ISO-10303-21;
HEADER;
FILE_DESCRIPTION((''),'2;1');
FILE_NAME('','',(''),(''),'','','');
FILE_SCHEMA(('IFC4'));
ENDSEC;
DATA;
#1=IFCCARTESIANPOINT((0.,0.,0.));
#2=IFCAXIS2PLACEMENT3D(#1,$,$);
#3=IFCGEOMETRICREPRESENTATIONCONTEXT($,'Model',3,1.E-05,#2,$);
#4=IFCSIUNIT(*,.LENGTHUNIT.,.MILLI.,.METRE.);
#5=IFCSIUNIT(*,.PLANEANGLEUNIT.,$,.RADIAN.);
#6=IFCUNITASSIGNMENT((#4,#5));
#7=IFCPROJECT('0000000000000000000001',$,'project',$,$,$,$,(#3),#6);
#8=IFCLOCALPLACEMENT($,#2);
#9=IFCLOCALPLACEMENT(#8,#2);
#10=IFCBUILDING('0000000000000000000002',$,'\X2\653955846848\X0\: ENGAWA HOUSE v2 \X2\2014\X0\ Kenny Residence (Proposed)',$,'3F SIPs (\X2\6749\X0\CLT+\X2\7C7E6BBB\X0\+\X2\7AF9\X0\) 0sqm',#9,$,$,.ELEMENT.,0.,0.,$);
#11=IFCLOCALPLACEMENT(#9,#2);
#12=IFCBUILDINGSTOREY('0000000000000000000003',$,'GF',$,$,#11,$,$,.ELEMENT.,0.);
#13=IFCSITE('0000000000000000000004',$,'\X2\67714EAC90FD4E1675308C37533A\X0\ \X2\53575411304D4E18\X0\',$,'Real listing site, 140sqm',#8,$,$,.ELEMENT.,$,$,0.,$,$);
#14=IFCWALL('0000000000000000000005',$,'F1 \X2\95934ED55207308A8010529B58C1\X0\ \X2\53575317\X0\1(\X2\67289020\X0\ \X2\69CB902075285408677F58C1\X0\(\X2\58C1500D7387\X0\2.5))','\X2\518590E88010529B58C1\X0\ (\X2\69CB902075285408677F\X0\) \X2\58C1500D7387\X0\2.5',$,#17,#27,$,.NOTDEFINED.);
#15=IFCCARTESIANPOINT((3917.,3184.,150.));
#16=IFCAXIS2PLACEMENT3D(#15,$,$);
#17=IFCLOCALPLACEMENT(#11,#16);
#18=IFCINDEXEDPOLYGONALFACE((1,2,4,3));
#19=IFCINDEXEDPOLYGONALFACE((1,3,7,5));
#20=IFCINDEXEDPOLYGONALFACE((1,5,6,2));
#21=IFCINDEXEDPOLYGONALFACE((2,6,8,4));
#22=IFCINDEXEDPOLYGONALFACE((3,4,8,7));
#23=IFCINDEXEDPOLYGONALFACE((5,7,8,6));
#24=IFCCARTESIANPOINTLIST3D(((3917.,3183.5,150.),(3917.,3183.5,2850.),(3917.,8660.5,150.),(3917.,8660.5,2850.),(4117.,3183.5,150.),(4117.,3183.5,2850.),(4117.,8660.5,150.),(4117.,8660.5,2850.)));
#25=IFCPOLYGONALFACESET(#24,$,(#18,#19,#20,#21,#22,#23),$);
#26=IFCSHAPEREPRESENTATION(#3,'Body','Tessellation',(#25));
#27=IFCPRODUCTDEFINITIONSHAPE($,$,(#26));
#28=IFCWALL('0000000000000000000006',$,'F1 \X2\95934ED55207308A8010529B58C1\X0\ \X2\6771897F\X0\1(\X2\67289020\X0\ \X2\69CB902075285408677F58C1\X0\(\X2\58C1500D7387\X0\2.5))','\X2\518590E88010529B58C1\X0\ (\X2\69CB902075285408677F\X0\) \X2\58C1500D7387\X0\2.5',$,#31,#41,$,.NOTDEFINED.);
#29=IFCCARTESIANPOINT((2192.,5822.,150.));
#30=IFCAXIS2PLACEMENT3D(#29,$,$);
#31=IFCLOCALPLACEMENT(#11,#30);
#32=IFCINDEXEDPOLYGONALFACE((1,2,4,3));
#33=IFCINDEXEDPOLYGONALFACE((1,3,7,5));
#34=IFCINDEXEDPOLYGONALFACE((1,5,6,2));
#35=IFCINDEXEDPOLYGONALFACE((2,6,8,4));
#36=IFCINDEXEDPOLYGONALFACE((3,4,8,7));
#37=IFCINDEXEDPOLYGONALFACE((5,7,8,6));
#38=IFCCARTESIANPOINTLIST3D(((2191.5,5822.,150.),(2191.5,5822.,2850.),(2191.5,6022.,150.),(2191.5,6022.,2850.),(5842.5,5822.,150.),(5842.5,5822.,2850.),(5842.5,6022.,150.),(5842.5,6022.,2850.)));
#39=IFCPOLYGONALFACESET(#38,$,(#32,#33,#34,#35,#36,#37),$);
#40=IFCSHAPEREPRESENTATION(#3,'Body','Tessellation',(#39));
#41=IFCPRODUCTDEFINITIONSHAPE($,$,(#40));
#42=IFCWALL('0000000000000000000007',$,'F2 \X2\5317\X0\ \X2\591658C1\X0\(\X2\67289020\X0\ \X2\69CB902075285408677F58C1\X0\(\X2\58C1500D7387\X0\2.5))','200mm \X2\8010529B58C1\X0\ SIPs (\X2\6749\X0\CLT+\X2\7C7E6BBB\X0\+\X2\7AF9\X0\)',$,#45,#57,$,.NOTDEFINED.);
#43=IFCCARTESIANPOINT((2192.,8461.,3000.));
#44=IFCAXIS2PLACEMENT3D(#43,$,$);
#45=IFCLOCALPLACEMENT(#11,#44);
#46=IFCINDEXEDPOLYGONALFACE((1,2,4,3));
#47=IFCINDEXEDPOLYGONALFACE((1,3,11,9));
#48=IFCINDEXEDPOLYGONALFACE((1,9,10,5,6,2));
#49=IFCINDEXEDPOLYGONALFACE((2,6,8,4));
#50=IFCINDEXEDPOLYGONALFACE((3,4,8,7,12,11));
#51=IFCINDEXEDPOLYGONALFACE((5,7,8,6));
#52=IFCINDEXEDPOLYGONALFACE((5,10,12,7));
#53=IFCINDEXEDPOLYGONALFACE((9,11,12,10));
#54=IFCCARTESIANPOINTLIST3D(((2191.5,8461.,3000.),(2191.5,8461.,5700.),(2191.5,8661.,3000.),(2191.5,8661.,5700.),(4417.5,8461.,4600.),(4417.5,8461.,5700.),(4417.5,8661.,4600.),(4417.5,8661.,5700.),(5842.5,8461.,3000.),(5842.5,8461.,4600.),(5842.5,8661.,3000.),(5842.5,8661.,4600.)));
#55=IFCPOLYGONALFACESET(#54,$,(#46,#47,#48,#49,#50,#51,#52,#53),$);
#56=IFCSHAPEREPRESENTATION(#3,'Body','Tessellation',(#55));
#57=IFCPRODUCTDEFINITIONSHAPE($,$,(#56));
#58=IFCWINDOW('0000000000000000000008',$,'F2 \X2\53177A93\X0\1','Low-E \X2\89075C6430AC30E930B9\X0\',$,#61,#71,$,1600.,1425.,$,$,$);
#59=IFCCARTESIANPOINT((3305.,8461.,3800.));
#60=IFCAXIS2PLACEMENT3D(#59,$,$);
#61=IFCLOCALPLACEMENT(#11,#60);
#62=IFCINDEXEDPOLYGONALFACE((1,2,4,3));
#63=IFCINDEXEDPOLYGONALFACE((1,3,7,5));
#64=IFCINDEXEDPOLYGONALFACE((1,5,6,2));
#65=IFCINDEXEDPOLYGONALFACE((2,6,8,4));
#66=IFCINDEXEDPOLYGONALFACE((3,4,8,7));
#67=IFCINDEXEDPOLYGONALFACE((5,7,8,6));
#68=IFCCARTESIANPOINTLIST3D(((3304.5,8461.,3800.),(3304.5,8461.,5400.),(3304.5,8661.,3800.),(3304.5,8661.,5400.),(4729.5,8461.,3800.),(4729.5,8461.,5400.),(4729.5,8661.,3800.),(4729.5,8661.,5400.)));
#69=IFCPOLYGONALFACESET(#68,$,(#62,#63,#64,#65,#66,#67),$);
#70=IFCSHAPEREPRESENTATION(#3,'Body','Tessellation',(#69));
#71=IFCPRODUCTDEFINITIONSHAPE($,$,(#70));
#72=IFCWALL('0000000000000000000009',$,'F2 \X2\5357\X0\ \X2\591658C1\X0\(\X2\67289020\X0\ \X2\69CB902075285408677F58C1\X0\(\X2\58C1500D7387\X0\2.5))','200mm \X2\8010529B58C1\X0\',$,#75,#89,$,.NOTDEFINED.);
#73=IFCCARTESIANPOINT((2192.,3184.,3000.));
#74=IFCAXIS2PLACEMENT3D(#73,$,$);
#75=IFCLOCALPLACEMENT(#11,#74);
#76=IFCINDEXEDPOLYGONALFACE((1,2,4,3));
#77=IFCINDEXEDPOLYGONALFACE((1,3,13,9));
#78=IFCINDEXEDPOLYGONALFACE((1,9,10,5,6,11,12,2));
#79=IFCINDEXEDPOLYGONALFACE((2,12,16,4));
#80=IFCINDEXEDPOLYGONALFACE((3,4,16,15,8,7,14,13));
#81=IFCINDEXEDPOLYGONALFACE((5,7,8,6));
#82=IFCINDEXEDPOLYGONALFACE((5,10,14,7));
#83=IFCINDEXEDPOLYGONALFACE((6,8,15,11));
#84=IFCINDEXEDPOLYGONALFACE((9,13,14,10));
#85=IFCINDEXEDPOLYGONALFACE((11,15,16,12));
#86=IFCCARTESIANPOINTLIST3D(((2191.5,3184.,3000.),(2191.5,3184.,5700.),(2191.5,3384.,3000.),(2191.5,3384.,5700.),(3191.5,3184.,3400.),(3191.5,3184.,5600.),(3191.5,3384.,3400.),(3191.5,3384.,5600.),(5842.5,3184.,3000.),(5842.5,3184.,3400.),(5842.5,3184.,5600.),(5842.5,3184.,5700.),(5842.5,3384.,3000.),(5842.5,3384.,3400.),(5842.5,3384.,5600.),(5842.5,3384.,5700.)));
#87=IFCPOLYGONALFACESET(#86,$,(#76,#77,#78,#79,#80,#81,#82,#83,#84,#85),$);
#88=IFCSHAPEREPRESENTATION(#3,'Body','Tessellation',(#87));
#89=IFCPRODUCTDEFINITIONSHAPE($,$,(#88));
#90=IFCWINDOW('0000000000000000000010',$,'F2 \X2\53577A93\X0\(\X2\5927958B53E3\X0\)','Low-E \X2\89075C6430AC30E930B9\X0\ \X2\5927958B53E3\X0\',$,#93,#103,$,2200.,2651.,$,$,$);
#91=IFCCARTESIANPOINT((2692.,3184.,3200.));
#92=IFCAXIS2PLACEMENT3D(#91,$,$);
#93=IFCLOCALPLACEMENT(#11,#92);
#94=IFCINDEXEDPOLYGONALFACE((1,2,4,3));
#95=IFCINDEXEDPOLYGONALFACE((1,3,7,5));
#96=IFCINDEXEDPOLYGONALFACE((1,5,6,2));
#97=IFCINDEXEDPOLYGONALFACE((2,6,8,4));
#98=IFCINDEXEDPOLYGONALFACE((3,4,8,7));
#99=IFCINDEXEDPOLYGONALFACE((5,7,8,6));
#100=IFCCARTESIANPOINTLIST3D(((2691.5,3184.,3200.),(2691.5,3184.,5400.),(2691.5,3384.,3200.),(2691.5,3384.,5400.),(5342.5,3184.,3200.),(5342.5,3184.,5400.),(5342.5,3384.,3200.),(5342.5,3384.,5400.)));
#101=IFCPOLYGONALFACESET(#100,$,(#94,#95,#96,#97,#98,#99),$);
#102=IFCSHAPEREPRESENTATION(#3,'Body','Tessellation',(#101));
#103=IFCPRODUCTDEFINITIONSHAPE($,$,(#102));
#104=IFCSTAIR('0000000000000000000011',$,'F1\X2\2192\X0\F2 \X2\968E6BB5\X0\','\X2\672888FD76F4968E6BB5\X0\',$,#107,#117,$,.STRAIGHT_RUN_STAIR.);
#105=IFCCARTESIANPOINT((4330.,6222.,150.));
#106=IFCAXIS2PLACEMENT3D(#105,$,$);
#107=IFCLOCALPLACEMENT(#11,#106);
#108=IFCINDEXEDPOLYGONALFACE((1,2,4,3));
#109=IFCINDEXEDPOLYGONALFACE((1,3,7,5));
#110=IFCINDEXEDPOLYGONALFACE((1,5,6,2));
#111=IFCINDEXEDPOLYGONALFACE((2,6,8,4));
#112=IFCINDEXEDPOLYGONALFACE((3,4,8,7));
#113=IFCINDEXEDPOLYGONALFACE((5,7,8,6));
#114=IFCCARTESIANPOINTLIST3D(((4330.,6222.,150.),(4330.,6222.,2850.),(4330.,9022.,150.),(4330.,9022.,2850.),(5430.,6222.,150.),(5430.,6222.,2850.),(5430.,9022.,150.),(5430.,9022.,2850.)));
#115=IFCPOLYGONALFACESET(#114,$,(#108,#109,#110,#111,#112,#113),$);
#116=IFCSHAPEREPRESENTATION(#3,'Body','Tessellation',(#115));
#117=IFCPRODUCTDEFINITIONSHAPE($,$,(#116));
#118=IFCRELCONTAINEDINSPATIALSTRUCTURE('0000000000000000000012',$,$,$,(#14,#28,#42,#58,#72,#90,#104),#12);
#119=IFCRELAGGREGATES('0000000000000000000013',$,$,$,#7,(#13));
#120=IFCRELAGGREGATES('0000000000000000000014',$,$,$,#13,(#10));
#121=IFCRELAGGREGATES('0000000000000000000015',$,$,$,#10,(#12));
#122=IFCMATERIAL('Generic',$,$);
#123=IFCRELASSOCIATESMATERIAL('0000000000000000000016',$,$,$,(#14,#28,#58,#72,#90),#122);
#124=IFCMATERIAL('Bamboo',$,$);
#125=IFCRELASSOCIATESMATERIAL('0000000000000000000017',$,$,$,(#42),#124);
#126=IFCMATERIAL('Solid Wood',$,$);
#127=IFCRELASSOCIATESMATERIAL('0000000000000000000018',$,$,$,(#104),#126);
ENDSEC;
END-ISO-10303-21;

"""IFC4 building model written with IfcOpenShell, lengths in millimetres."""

from ifc_helpers import new_model, si_unit, frame, frame_2d, origin, place, context, project, spatial, rectangle, extrude, material, element, fill, save


model = new_model("IFC4")

# Units and contexts
model_context = context("Model", 3, precision=1e-05, world=origin())
ifc_project = project(units=[si_unit("LENGTHUNIT", "METRE", prefix="MILLI"), si_unit("PLANEANGLEUNIT", "RADIAN")], contexts=[model_context])

# Site, building, storey
site_placement = place(None, origin())
site = spatial("IfcSite", under=ifc_project, at=site_placement, Name="東京都世田谷区 南向き丘", ObjectType="Real listing site, 140sqm", CompositionType="ELEMENT", RefElevation=0.0)
building_placement = place(site_placement, origin())
building = spatial("IfcBuilding", under=site, at=building_placement, Name="改善案: ENGAWA HOUSE v2 — Kenny Residence (Proposed)", ObjectType="3F SIPs (杉CLT+籾殻+竹) 0sqm", CompositionType="ELEMENT", ElevationOfRefHeight=0.0, ElevationOfTerrain=0.0)
storey_placement = place(building_placement, origin())
storey = spatial("IfcBuildingStorey", under=building, at=storey_placement, Name="GF", CompositionType="ELEMENT", Elevation=0.0)

# Shared definitions
ifc_material_1 = material(Name="Generic")

# Shared definitions
ifc_material_2 = material(Name="Bamboo")

# Shared definitions
ifc_material_3 = material(Name="Solid Wood")

# Walls
wall_1_placement = place(storey_placement, frame((3917.0, 3184.0, 150.0)))
element("IfcWall", 1, at=wall_1_placement, inside=storey, material=ifc_material_1, Name="F1 間仕切り耐力壁 南北1(木造 構造用合板壁(壁倍率2.5))", Description="内部耐力壁 (構造用合板) 壁倍率2.5", PredefinedType="NOTDEFINED", context=model_context, shape_type="SweptSolid", body=[
    extrude(rectangle(XDim=200.0, YDim=5477.0, at=frame_2d((100.0, 2738.0))), frame((3917.0, 3184.0, 150.0)), (0.0, 0.0, 1.0), 2700.0),
])
wall_2_placement = place(storey_placement, frame((2192.0, 5822.0, 150.0)))
element("IfcWall", 2, at=wall_2_placement, inside=storey, material=ifc_material_1, Name="F1 間仕切り耐力壁 東西1(木造 構造用合板壁(壁倍率2.5))", Description="内部耐力壁 (構造用合板) 壁倍率2.5", PredefinedType="NOTDEFINED", context=model_context, shape_type="SweptSolid", body=[
    extrude(rectangle(XDim=3651.0, YDim=200.0, at=frame_2d((1825.0, 100.0))), frame((2192.0, 5822.0, 150.0)), (0.0, 0.0, 1.0), 2700.0),
])

# Walls, openings, windows
wall_3_placement = place(storey_placement, frame((2192.0, 8461.0, 3000.0)))
wall_3 = element("IfcWall", 3, at=wall_3_placement, inside=storey, material=ifc_material_2, Name="F2 北 外壁(木造 構造用合板壁(壁倍率2.5))", Description="200mm 耐力壁 SIPs (杉CLT+籾殻+竹)", PredefinedType="NOTDEFINED", context=model_context, shape_type="SweptSolid", body=[
    extrude(rectangle(XDim=3651.0, YDim=200.0, at=frame_2d((1825.0, 100.0))), frame((2192.0, 8461.0, 3000.0)), (0.0, 0.0, 1.0), 2700.0),
])
opening_1_placement = place(storey_placement, frame((3305.0, 8461.0, 3800.0)))
opening_1 = element("IfcOpeningElement", 4, at=opening_1_placement, cuts=wall_3, PredefinedType="NOTDEFINED", context=model_context, shape_type="SweptSolid", body=[
    extrude(rectangle(XDim=1425.0, YDim=200.0, at=frame_2d((712.0, 100.0))), frame((3305.0, 8461.0, 3800.0)), (0.0, 0.0, 1.0), 1600.0),
])
window_1_placement = place(storey_placement, frame((3305.0, 8461.0, 3800.0)))
window_1 = element("IfcWindow", 5, at=window_1_placement, inside=storey, material=ifc_material_1, Name="F2 北窓1", Description="Low-E 複層ガラス", OverallHeight=1600.0, OverallWidth=1425.0, context=model_context, shape_type="SweptSolid", body=[
    extrude(rectangle(XDim=1425.0, YDim=200.0, at=frame_2d((712.0, 100.0))), frame((3305.0, 8461.0, 3800.0)), (0.0, 0.0, 1.0), 1600.0),
])
fill(opening_1, window_1)
wall_4_placement = place(storey_placement, frame((2192.0, 3184.0, 3000.0)))
wall_4 = element("IfcWall", 6, at=wall_4_placement, inside=storey, material=ifc_material_1, Name="F2 南 外壁(木造 構造用合板壁(壁倍率2.5))", Description="200mm 耐力壁", PredefinedType="NOTDEFINED", context=model_context, shape_type="SweptSolid", body=[
    extrude(rectangle(XDim=3651.0, YDim=200.0, at=frame_2d((1825.0, 100.0))), frame((2192.0, 3184.0, 3000.0)), (0.0, 0.0, 1.0), 2700.0),
])
opening_2_placement = place(storey_placement, frame((2692.0, 3184.0, 3200.0)))
opening_2 = element("IfcOpeningElement", 7, at=opening_2_placement, cuts=wall_4, PredefinedType="NOTDEFINED", context=model_context, shape_type="SweptSolid", body=[
    extrude(rectangle(XDim=2651.0, YDim=200.0, at=frame_2d((1325.0, 100.0))), frame((2692.0, 3184.0, 3200.0)), (0.0, 0.0, 1.0), 2200.0),
])
window_2_placement = place(storey_placement, frame((2692.0, 3184.0, 3200.0)))
window_2 = element("IfcWindow", 8, at=window_2_placement, inside=storey, material=ifc_material_1, Name="F2 南窓(大開口)", Description="Low-E 複層ガラス 大開口", OverallHeight=2200.0, OverallWidth=2651.0, context=model_context, shape_type="SweptSolid", body=[
    extrude(rectangle(XDim=2651.0, YDim=200.0, at=frame_2d((1325.0, 100.0))), frame((2692.0, 3184.0, 3200.0)), (0.0, 0.0, 1.0), 2200.0),
])
fill(opening_2, window_2)

# Stair
stair_placement = place(storey_placement, frame((4330.0, 6222.0, 150.0)))
element("IfcStair", 9, at=stair_placement, inside=storey, material=ifc_material_3, Name="F1→F2 階段", Description="木製直階段", PredefinedType="STRAIGHT_RUN_STAIR", context=model_context, shape_type="SweptSolid", body=[
    extrude(rectangle(XDim=1100.0, YDim=2800.0, at=frame_2d((550.0, 1400.0))), frame((4330.0, 6222.0, 150.0)), (0.0, 0.0, 1.0), 2700.0),
])

save(model, "model.ifc")
